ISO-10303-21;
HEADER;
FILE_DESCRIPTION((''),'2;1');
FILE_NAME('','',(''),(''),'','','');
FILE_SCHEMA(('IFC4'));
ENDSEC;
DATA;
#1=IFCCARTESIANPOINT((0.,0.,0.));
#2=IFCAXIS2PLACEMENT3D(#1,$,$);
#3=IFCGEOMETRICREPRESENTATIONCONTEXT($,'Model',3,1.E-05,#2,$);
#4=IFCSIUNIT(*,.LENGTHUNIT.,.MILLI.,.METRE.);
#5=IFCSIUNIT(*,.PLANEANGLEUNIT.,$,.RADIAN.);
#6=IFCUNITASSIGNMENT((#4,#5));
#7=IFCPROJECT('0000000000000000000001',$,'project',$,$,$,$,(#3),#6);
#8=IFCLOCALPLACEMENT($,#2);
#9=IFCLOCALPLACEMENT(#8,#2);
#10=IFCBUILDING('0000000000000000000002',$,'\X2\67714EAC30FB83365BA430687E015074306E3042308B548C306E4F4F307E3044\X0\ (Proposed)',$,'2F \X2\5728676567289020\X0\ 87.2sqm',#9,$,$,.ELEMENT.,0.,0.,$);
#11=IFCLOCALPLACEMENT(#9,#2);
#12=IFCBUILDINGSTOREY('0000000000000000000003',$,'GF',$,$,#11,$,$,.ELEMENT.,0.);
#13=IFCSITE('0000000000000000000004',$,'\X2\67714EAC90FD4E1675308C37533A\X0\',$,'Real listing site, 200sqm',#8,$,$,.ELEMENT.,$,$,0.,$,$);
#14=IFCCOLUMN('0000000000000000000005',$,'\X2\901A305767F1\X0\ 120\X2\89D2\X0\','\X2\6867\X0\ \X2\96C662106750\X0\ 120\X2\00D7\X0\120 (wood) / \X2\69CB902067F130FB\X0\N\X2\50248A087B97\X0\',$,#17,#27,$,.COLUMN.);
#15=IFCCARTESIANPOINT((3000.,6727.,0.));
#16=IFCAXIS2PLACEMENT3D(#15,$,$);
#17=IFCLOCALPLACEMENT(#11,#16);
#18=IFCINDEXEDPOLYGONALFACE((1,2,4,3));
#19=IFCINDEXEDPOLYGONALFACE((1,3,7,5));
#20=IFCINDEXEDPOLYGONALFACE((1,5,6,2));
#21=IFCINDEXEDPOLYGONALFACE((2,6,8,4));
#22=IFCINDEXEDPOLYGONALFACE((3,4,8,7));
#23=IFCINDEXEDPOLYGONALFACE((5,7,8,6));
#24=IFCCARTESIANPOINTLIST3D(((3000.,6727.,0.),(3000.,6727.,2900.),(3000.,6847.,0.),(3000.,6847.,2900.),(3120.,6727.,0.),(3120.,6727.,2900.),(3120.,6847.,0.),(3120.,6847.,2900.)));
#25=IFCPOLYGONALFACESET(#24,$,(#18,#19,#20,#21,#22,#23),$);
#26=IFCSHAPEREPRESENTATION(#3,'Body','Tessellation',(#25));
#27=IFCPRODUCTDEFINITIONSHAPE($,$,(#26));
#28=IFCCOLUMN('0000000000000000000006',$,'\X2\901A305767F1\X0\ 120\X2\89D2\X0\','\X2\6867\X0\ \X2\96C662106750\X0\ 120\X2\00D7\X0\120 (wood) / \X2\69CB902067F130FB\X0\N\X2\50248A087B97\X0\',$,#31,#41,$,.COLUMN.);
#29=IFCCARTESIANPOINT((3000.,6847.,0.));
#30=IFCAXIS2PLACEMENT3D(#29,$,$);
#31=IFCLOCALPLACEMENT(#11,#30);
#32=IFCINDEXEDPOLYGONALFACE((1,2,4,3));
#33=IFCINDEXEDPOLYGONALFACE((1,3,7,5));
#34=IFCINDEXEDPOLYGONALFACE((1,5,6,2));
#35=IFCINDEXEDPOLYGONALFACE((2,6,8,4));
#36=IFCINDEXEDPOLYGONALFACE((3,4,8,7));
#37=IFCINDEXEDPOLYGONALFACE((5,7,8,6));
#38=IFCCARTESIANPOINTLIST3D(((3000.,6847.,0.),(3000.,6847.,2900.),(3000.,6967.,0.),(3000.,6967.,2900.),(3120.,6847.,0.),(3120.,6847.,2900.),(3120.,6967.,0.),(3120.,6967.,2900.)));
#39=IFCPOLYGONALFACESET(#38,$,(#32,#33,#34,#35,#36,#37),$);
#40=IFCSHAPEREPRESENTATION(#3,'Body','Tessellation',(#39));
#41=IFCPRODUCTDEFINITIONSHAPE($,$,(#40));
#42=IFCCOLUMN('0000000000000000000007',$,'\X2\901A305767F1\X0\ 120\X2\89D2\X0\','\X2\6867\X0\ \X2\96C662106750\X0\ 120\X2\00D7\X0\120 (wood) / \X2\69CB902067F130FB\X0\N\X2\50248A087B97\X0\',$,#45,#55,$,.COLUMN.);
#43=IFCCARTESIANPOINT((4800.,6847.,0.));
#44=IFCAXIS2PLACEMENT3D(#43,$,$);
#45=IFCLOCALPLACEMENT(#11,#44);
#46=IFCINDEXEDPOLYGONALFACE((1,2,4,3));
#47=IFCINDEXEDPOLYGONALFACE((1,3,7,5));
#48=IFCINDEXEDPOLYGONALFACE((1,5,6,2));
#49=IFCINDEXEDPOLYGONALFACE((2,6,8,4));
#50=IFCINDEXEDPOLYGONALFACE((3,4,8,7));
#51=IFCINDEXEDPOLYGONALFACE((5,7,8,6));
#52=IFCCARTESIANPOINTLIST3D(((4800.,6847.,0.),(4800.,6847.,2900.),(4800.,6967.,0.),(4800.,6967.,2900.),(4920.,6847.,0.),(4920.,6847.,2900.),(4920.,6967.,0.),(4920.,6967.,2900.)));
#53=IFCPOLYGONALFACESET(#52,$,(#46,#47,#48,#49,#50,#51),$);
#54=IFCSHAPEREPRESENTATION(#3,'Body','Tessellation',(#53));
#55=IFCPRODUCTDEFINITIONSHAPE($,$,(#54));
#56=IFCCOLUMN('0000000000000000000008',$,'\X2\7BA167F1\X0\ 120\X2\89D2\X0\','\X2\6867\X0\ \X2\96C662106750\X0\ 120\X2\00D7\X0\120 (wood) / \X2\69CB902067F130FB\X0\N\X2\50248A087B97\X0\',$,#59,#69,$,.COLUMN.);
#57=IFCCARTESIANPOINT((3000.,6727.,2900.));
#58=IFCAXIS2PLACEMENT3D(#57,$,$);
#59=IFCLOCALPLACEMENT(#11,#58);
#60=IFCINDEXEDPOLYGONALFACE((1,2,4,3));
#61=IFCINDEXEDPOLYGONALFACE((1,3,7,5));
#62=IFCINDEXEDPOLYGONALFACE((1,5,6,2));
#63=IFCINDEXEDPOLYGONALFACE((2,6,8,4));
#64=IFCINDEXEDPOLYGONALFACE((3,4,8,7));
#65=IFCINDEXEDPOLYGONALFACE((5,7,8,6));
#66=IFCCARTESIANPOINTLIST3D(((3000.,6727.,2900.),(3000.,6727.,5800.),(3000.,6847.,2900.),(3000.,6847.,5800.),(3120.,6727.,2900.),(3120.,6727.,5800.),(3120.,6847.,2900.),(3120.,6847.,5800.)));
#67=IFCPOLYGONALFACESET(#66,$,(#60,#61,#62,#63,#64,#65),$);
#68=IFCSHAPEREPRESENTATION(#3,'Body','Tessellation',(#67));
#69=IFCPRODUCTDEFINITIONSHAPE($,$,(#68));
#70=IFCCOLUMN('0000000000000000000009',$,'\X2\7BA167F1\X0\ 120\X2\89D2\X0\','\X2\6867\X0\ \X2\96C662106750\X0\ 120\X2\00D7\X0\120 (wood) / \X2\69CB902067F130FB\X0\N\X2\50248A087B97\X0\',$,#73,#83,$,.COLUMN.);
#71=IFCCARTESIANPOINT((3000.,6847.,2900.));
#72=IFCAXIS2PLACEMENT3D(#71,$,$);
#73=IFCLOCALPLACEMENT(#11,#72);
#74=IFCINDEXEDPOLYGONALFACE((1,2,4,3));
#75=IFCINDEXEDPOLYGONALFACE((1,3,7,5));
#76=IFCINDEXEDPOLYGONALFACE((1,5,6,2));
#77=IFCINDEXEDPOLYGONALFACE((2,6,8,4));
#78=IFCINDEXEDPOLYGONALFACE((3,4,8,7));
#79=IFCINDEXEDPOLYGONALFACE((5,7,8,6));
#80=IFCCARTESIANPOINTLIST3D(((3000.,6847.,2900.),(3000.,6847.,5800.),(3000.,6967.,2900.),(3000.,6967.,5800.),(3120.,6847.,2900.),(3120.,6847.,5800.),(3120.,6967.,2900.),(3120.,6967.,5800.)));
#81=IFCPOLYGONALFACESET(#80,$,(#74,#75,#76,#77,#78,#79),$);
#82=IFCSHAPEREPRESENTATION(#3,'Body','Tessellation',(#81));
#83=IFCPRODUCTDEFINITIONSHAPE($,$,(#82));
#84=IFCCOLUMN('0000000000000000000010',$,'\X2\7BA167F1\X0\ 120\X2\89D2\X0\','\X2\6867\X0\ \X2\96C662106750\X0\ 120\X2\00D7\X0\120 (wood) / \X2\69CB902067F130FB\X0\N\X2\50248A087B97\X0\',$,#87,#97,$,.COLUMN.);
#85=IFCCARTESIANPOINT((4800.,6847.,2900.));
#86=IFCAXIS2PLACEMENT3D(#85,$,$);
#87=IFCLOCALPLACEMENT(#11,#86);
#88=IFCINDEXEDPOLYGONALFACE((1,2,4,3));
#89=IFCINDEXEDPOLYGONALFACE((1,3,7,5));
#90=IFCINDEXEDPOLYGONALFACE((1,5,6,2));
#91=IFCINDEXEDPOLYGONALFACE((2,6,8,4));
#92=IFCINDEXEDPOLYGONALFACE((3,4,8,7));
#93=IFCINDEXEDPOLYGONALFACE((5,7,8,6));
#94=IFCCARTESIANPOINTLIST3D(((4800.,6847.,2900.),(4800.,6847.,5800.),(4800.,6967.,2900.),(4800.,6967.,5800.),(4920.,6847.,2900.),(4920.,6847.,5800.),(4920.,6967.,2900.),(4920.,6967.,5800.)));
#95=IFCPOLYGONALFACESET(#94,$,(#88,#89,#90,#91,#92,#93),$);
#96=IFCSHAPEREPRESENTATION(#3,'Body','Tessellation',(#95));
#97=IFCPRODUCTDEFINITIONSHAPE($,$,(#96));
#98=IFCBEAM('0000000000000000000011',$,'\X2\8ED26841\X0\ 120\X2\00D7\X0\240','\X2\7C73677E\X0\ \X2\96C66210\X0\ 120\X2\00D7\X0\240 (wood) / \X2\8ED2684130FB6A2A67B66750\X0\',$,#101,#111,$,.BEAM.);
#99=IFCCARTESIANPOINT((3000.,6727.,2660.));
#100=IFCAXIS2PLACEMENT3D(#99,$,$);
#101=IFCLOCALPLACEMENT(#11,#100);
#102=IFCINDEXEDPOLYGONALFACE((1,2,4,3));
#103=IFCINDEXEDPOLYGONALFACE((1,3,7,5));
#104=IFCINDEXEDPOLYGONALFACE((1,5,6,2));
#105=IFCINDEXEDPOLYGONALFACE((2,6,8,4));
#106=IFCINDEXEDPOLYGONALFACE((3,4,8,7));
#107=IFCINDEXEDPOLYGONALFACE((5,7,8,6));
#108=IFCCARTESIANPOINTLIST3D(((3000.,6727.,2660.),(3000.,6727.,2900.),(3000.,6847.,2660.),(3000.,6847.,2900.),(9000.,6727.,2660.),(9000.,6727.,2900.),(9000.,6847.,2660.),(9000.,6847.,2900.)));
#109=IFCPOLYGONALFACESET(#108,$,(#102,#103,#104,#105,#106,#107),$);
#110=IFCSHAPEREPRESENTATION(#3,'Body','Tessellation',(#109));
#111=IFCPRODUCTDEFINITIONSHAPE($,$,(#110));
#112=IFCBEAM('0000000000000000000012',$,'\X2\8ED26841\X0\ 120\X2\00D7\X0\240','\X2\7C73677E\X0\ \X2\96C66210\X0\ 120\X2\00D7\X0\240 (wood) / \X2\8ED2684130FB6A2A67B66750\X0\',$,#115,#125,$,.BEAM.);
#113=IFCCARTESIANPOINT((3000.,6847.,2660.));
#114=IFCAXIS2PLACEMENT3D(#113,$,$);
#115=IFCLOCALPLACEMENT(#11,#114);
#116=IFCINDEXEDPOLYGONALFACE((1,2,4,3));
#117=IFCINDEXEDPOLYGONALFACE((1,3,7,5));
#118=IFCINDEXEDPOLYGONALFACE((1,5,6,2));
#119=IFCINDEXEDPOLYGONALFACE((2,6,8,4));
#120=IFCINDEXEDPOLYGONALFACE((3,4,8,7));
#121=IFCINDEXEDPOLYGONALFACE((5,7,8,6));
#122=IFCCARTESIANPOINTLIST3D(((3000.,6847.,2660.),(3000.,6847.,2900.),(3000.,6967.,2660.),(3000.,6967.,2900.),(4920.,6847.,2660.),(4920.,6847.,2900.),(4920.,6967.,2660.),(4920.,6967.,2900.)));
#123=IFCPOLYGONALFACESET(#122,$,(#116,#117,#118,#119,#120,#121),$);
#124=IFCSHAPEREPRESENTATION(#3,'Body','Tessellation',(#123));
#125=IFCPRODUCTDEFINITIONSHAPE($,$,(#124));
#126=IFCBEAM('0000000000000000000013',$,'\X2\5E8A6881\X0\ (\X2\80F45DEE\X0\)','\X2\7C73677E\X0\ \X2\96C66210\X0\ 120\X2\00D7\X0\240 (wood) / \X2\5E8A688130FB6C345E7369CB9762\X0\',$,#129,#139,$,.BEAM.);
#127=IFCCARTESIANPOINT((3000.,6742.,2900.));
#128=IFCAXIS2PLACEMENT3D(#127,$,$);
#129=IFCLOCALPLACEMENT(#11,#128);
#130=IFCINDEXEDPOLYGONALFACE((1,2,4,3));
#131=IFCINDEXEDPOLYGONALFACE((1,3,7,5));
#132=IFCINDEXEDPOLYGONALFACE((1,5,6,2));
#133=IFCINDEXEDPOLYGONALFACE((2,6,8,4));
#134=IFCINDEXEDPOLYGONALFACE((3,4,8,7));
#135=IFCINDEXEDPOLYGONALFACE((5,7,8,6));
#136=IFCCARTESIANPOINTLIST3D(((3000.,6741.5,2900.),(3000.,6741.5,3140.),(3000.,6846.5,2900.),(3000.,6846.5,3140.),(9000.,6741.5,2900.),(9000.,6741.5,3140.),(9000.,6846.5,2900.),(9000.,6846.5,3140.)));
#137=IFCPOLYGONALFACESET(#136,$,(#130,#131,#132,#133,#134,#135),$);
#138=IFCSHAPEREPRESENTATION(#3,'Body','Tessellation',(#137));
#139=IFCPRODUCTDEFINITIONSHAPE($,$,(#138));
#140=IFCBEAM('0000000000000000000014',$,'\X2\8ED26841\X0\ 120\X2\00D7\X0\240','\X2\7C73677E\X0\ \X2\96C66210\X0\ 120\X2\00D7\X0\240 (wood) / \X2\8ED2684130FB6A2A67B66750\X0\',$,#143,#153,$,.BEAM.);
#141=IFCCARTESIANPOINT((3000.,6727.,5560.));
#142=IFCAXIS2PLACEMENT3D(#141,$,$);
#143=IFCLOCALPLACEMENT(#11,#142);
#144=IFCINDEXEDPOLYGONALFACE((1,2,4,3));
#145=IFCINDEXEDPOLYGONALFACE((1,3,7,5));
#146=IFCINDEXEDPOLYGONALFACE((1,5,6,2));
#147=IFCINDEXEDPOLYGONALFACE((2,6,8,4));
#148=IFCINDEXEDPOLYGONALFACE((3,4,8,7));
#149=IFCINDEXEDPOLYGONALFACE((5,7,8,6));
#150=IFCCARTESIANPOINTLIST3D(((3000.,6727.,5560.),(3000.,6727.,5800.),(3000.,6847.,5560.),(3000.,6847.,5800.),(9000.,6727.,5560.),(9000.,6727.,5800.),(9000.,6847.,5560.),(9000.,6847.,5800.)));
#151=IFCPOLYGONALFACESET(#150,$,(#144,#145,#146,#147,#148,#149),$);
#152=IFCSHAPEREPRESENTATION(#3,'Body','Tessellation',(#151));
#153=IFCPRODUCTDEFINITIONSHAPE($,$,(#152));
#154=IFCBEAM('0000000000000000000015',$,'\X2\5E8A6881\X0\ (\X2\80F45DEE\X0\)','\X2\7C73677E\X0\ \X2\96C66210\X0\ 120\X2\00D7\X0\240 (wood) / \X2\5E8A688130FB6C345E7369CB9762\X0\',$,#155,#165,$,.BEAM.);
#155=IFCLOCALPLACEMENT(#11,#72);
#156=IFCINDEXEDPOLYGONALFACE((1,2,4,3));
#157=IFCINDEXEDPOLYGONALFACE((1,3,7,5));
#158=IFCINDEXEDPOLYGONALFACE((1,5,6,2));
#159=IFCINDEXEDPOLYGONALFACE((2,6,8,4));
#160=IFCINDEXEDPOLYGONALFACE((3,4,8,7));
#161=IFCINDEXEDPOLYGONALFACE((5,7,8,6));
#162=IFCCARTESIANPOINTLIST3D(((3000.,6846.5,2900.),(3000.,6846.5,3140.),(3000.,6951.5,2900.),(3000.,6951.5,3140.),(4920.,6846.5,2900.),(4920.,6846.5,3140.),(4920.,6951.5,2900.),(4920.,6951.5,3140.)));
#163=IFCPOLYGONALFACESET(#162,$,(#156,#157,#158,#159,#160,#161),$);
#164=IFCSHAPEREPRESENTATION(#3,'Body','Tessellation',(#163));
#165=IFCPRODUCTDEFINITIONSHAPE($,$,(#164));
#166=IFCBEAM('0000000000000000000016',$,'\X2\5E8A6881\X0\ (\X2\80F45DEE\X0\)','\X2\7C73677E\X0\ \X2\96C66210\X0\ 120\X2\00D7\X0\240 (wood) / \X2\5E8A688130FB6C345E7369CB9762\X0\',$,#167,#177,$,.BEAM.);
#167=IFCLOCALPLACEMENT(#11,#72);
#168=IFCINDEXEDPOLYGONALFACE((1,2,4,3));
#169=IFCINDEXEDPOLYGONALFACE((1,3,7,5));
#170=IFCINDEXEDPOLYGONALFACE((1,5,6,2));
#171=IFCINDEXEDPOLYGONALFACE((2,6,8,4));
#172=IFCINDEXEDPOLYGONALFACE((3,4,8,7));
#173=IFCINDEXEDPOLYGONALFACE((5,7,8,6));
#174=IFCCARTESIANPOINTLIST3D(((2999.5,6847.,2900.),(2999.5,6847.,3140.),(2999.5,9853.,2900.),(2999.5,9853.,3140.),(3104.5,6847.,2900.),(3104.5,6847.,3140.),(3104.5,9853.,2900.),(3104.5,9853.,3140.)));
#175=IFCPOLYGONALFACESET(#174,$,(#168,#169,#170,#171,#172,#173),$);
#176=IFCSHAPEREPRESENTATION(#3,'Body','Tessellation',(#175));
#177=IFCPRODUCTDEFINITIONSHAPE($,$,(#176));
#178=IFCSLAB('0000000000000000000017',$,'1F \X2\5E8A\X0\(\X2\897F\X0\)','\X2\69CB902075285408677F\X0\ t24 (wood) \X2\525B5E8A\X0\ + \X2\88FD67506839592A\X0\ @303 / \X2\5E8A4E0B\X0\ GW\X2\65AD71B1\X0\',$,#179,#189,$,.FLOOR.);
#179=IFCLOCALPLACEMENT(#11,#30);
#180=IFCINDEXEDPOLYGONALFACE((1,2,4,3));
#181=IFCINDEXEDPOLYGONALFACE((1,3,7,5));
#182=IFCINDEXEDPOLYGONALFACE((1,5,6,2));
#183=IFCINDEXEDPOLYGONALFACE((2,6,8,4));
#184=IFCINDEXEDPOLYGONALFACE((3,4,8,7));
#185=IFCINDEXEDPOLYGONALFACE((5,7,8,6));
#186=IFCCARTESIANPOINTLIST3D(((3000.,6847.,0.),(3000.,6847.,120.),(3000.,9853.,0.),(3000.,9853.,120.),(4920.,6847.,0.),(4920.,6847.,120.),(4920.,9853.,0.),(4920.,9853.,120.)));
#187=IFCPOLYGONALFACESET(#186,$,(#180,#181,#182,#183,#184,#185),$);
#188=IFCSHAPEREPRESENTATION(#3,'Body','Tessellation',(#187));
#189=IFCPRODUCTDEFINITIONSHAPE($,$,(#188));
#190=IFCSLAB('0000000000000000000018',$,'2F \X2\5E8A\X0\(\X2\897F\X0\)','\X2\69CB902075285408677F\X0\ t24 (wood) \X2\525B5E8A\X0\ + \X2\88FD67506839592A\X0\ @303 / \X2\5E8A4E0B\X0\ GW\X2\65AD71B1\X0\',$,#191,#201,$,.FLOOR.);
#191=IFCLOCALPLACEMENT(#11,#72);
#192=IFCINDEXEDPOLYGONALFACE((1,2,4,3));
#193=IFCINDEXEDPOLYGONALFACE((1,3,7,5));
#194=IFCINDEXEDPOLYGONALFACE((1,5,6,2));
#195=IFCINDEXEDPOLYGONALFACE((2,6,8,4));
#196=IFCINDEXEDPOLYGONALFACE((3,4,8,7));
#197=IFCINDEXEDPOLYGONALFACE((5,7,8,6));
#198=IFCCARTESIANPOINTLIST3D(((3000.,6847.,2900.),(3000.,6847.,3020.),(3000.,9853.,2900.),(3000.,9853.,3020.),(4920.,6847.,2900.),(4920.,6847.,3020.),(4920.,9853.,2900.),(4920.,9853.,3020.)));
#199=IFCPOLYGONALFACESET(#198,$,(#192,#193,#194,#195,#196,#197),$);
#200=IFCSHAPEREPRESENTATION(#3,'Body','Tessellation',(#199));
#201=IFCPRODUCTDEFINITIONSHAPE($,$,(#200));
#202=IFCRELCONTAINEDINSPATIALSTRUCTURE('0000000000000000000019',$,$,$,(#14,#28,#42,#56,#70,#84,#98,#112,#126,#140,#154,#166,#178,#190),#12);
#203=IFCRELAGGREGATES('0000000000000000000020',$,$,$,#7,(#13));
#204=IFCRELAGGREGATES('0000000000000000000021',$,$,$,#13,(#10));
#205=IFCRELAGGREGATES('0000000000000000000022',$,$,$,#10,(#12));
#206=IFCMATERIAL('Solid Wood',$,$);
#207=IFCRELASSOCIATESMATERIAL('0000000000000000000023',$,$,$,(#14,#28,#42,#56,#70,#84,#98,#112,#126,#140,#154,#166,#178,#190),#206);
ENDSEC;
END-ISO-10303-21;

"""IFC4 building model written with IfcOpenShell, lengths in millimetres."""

from ifc_helpers import new_model, si_unit, frame, frame_2d, origin, place, context, project, spatial, rectangle, extrude, material, element, save


model = new_model("IFC4")

# Units and contexts
model_context = context("Model", 3, precision=1e-05, world=origin())
ifc_project = project(units=[si_unit("LENGTHUNIT", "METRE", prefix="MILLI"), si_unit("PLANEANGLEUNIT", "RADIAN")], contexts=[model_context])

# Site, building, storey
site_placement = place(None, origin())
site = spatial("IfcSite", under=ifc_project, at=site_placement, Name="東京都世田谷区", ObjectType="Real listing site, 200sqm", CompositionType="ELEMENT", RefElevation=0.0)
building_placement = place(site_placement, origin())
building = spatial("IfcBuilding", under=site, at=building_placement, Name="東京・茶室と縁側のある和の住まい (Proposed)", ObjectType="2F 在来木造 87.2sqm", CompositionType="ELEMENT", ElevationOfRefHeight=0.0, ElevationOfTerrain=0.0)
storey_placement = place(building_placement, origin())
storey = spatial("IfcBuildingStorey", under=building, at=storey_placement, Name="GF", CompositionType="ELEMENT", Elevation=0.0)

# Columns
ifc_material_1 = material(Name="Solid Wood")
column_1_placement = place(storey_placement, frame((3000.0, 6727.0, 0.0)))
element("IfcColumn", 1, at=column_1_placement, inside=storey, material=ifc_material_1, Name="通し柱 120角", Description="桧 集成材 120×120 (wood) / 構造柱・N値計算", PredefinedType="COLUMN", context=model_context, shape_type="SweptSolid", body=[
    extrude(rectangle(XDim=120.0, YDim=120.0, at=frame_2d((60.0, 60.0))), frame((3000.0, 6727.0, 0.0)), (0.0, 0.0, 1.0), 2900.0),
])
column_2_placement = place(storey_placement, frame((3000.0, 6847.0, 0.0)))
element("IfcColumn", 2, at=column_2_placement, inside=storey, material=ifc_material_1, Name="通し柱 120角", Description="桧 集成材 120×120 (wood) / 構造柱・N値計算", PredefinedType="COLUMN", context=model_context, shape_type="SweptSolid", body=[
    extrude(rectangle(XDim=120.0, YDim=120.0, at=frame_2d((60.0, 60.0))), frame((3000.0, 6847.0, 0.0)), (0.0, 0.0, 1.0), 2900.0),
])
column_3_placement = place(storey_placement, frame((4800.0, 6847.0, 0.0)))
element("IfcColumn", 3, at=column_3_placement, inside=storey, material=ifc_material_1, Name="通し柱 120角", Description="桧 集成材 120×120 (wood) / 構造柱・N値計算", PredefinedType="COLUMN", context=model_context, shape_type="SweptSolid", body=[
    extrude(rectangle(XDim=120.0, YDim=120.0, at=frame_2d((60.0, 60.0))), frame((4800.0, 6847.0, 0.0)), (0.0, 0.0, 1.0), 2900.0),
])
column_4_placement = place(storey_placement, frame((3000.0, 6727.0, 2900.0)))
element("IfcColumn", 4, at=column_4_placement, inside=storey, material=ifc_material_1, Name="管柱 120角", Description="桧 集成材 120×120 (wood) / 構造柱・N値計算", PredefinedType="COLUMN", context=model_context, shape_type="SweptSolid", body=[
    extrude(rectangle(XDim=120.0, YDim=120.0, at=frame_2d((60.0, 60.0))), frame((3000.0, 6727.0, 2900.0)), (0.0, 0.0, 1.0), 2900.0),
])
column_5_placement = place(storey_placement, frame((3000.0, 6847.0, 2900.0)))
element("IfcColumn", 5, at=column_5_placement, inside=storey, material=ifc_material_1, Name="管柱 120角", Description="桧 集成材 120×120 (wood) / 構造柱・N値計算", PredefinedType="COLUMN", context=model_context, shape_type="SweptSolid", body=[
    extrude(rectangle(XDim=120.0, YDim=120.0, at=frame_2d((60.0, 60.0))), frame((3000.0, 6847.0, 2900.0)), (0.0, 0.0, 1.0), 2900.0),
])
column_6_placement = place(storey_placement, frame((4800.0, 6847.0, 2900.0)))
element("IfcColumn", 6, at=column_6_placement, inside=storey, material=ifc_material_1, Name="管柱 120角", Description="桧 集成材 120×120 (wood) / 構造柱・N値計算", PredefinedType="COLUMN", context=model_context, shape_type="SweptSolid", body=[
    extrude(rectangle(XDim=120.0, YDim=120.0, at=frame_2d((60.0, 60.0))), frame((4800.0, 6847.0, 2900.0)), (0.0, 0.0, 1.0), 2900.0),
])

# Beams
beam_1_placement = place(storey_placement, frame((3000.0, 6727.0, 2660.0)))
element("IfcBeam", 7, at=beam_1_placement, inside=storey, material=ifc_material_1, Name="軒桁 120×240", Description="米松 集成 120×240 (wood) / 軒桁・横架材", PredefinedType="BEAM", context=model_context, shape_type="SweptSolid", body=[
    extrude(rectangle(XDim=6000.0, YDim=120.0, at=frame_2d((3000.0, 60.0))), frame((3000.0, 6727.0, 2660.0)), (0.0, 0.0, 1.0), 240.0),
])
beam_2_placement = place(storey_placement, frame((3000.0, 6847.0, 2660.0)))
element("IfcBeam", 8, at=beam_2_placement, inside=storey, material=ifc_material_1, Name="軒桁 120×240", Description="米松 集成 120×240 (wood) / 軒桁・横架材", PredefinedType="BEAM", context=model_context, shape_type="SweptSolid", body=[
    extrude(rectangle(XDim=1920.0, YDim=120.0, at=frame_2d((960.0, 60.0))), frame((3000.0, 6847.0, 2660.0)), (0.0, 0.0, 1.0), 240.0),
])
beam_3_placement = place(storey_placement, frame((3000.0, 6742.0, 2900.0)))
element("IfcBeam", 9, at=beam_3_placement, inside=storey, material=ifc_material_1, Name="床梁 (胴差)", Description="米松 集成 120×240 (wood) / 床梁・水平構面", PredefinedType="BEAM", context=model_context, shape_type="SweptSolid", body=[
    extrude(rectangle(XDim=6000.0, YDim=105.0, at=frame_2d((3000.0, 52.0))), frame((3000.0, 6742.0, 2900.0)), (0.0, 0.0, 1.0), 240.0),
])
beam_4_placement = place(storey_placement, frame((3000.0, 6727.0, 5560.0)))
element("IfcBeam", 10, at=beam_4_placement, inside=storey, material=ifc_material_1, Name="軒桁 120×240", Description="米松 集成 120×240 (wood) / 軒桁・横架材", PredefinedType="BEAM", context=model_context, shape_type="SweptSolid", body=[
    extrude(rectangle(XDim=6000.0, YDim=120.0, at=frame_2d((3000.0, 60.0))), frame((3000.0, 6727.0, 5560.0)), (0.0, 0.0, 1.0), 240.0),
])
beam_5_placement = place(storey_placement, frame((3000.0, 6847.0, 2900.0)))
element("IfcBeam", 11, at=beam_5_placement, inside=storey, material=ifc_material_1, Name="床梁 (胴差)", Description="米松 集成 120×240 (wood) / 床梁・水平構面", PredefinedType="BEAM", context=model_context, shape_type="SweptSolid", body=[
    extrude(rectangle(XDim=1920.0, YDim=105.0, at=frame_2d((960.0, 52.0))), frame((3000.0, 6847.0, 2900.0)), (0.0, 0.0, 1.0), 240.0),
])
beam_6_placement = place(storey_placement, frame((3000.0, 6847.0, 2900.0)))
element("IfcBeam", 12, at=beam_6_placement, inside=storey, material=ifc_material_1, Name="床梁 (胴差)", Description="米松 集成 120×240 (wood) / 床梁・水平構面", PredefinedType="BEAM", context=model_context, shape_type="SweptSolid", body=[
    extrude(rectangle(XDim=105.0, YDim=3006.0, at=frame_2d((52.0, 1503.0))), frame((3000.0, 6847.0, 2900.0)), (0.0, 0.0, 1.0), 240.0),
])

# Slabs
slab_1_placement = place(storey_placement, frame((3000.0, 6847.0, 0.0)))
element("IfcSlab", 13, at=slab_1_placement, inside=storey, material=ifc_material_1, Name="1F 床(西)", Description="構造用合板 t24 (wood) 剛床 + 製材根太 @303 / 床下 GW断熱", PredefinedType="FLOOR", context=model_context, shape_type="SweptSolid", body=[
    extrude(rectangle(XDim=1920.0, YDim=3006.0, at=frame_2d((960.0, 1503.0))), frame((3000.0, 6847.0, 0.0)), (0.0, 0.0, 1.0), 120.0),
])
slab_2_placement = place(storey_placement, frame((3000.0, 6847.0, 2900.0)))
element("IfcSlab", 14, at=slab_2_placement, inside=storey, material=ifc_material_1, Name="2F 床(西)", Description="構造用合板 t24 (wood) 剛床 + 製材根太 @303 / 床下 GW断熱", PredefinedType="FLOOR", context=model_context, shape_type="SweptSolid", body=[
    extrude(rectangle(XDim=1920.0, YDim=3006.0, at=frame_2d((960.0, 1503.0))), frame((3000.0, 6847.0, 2900.0)), (0.0, 0.0, 1.0), 120.0),
])

save(model, "model.ifc")
